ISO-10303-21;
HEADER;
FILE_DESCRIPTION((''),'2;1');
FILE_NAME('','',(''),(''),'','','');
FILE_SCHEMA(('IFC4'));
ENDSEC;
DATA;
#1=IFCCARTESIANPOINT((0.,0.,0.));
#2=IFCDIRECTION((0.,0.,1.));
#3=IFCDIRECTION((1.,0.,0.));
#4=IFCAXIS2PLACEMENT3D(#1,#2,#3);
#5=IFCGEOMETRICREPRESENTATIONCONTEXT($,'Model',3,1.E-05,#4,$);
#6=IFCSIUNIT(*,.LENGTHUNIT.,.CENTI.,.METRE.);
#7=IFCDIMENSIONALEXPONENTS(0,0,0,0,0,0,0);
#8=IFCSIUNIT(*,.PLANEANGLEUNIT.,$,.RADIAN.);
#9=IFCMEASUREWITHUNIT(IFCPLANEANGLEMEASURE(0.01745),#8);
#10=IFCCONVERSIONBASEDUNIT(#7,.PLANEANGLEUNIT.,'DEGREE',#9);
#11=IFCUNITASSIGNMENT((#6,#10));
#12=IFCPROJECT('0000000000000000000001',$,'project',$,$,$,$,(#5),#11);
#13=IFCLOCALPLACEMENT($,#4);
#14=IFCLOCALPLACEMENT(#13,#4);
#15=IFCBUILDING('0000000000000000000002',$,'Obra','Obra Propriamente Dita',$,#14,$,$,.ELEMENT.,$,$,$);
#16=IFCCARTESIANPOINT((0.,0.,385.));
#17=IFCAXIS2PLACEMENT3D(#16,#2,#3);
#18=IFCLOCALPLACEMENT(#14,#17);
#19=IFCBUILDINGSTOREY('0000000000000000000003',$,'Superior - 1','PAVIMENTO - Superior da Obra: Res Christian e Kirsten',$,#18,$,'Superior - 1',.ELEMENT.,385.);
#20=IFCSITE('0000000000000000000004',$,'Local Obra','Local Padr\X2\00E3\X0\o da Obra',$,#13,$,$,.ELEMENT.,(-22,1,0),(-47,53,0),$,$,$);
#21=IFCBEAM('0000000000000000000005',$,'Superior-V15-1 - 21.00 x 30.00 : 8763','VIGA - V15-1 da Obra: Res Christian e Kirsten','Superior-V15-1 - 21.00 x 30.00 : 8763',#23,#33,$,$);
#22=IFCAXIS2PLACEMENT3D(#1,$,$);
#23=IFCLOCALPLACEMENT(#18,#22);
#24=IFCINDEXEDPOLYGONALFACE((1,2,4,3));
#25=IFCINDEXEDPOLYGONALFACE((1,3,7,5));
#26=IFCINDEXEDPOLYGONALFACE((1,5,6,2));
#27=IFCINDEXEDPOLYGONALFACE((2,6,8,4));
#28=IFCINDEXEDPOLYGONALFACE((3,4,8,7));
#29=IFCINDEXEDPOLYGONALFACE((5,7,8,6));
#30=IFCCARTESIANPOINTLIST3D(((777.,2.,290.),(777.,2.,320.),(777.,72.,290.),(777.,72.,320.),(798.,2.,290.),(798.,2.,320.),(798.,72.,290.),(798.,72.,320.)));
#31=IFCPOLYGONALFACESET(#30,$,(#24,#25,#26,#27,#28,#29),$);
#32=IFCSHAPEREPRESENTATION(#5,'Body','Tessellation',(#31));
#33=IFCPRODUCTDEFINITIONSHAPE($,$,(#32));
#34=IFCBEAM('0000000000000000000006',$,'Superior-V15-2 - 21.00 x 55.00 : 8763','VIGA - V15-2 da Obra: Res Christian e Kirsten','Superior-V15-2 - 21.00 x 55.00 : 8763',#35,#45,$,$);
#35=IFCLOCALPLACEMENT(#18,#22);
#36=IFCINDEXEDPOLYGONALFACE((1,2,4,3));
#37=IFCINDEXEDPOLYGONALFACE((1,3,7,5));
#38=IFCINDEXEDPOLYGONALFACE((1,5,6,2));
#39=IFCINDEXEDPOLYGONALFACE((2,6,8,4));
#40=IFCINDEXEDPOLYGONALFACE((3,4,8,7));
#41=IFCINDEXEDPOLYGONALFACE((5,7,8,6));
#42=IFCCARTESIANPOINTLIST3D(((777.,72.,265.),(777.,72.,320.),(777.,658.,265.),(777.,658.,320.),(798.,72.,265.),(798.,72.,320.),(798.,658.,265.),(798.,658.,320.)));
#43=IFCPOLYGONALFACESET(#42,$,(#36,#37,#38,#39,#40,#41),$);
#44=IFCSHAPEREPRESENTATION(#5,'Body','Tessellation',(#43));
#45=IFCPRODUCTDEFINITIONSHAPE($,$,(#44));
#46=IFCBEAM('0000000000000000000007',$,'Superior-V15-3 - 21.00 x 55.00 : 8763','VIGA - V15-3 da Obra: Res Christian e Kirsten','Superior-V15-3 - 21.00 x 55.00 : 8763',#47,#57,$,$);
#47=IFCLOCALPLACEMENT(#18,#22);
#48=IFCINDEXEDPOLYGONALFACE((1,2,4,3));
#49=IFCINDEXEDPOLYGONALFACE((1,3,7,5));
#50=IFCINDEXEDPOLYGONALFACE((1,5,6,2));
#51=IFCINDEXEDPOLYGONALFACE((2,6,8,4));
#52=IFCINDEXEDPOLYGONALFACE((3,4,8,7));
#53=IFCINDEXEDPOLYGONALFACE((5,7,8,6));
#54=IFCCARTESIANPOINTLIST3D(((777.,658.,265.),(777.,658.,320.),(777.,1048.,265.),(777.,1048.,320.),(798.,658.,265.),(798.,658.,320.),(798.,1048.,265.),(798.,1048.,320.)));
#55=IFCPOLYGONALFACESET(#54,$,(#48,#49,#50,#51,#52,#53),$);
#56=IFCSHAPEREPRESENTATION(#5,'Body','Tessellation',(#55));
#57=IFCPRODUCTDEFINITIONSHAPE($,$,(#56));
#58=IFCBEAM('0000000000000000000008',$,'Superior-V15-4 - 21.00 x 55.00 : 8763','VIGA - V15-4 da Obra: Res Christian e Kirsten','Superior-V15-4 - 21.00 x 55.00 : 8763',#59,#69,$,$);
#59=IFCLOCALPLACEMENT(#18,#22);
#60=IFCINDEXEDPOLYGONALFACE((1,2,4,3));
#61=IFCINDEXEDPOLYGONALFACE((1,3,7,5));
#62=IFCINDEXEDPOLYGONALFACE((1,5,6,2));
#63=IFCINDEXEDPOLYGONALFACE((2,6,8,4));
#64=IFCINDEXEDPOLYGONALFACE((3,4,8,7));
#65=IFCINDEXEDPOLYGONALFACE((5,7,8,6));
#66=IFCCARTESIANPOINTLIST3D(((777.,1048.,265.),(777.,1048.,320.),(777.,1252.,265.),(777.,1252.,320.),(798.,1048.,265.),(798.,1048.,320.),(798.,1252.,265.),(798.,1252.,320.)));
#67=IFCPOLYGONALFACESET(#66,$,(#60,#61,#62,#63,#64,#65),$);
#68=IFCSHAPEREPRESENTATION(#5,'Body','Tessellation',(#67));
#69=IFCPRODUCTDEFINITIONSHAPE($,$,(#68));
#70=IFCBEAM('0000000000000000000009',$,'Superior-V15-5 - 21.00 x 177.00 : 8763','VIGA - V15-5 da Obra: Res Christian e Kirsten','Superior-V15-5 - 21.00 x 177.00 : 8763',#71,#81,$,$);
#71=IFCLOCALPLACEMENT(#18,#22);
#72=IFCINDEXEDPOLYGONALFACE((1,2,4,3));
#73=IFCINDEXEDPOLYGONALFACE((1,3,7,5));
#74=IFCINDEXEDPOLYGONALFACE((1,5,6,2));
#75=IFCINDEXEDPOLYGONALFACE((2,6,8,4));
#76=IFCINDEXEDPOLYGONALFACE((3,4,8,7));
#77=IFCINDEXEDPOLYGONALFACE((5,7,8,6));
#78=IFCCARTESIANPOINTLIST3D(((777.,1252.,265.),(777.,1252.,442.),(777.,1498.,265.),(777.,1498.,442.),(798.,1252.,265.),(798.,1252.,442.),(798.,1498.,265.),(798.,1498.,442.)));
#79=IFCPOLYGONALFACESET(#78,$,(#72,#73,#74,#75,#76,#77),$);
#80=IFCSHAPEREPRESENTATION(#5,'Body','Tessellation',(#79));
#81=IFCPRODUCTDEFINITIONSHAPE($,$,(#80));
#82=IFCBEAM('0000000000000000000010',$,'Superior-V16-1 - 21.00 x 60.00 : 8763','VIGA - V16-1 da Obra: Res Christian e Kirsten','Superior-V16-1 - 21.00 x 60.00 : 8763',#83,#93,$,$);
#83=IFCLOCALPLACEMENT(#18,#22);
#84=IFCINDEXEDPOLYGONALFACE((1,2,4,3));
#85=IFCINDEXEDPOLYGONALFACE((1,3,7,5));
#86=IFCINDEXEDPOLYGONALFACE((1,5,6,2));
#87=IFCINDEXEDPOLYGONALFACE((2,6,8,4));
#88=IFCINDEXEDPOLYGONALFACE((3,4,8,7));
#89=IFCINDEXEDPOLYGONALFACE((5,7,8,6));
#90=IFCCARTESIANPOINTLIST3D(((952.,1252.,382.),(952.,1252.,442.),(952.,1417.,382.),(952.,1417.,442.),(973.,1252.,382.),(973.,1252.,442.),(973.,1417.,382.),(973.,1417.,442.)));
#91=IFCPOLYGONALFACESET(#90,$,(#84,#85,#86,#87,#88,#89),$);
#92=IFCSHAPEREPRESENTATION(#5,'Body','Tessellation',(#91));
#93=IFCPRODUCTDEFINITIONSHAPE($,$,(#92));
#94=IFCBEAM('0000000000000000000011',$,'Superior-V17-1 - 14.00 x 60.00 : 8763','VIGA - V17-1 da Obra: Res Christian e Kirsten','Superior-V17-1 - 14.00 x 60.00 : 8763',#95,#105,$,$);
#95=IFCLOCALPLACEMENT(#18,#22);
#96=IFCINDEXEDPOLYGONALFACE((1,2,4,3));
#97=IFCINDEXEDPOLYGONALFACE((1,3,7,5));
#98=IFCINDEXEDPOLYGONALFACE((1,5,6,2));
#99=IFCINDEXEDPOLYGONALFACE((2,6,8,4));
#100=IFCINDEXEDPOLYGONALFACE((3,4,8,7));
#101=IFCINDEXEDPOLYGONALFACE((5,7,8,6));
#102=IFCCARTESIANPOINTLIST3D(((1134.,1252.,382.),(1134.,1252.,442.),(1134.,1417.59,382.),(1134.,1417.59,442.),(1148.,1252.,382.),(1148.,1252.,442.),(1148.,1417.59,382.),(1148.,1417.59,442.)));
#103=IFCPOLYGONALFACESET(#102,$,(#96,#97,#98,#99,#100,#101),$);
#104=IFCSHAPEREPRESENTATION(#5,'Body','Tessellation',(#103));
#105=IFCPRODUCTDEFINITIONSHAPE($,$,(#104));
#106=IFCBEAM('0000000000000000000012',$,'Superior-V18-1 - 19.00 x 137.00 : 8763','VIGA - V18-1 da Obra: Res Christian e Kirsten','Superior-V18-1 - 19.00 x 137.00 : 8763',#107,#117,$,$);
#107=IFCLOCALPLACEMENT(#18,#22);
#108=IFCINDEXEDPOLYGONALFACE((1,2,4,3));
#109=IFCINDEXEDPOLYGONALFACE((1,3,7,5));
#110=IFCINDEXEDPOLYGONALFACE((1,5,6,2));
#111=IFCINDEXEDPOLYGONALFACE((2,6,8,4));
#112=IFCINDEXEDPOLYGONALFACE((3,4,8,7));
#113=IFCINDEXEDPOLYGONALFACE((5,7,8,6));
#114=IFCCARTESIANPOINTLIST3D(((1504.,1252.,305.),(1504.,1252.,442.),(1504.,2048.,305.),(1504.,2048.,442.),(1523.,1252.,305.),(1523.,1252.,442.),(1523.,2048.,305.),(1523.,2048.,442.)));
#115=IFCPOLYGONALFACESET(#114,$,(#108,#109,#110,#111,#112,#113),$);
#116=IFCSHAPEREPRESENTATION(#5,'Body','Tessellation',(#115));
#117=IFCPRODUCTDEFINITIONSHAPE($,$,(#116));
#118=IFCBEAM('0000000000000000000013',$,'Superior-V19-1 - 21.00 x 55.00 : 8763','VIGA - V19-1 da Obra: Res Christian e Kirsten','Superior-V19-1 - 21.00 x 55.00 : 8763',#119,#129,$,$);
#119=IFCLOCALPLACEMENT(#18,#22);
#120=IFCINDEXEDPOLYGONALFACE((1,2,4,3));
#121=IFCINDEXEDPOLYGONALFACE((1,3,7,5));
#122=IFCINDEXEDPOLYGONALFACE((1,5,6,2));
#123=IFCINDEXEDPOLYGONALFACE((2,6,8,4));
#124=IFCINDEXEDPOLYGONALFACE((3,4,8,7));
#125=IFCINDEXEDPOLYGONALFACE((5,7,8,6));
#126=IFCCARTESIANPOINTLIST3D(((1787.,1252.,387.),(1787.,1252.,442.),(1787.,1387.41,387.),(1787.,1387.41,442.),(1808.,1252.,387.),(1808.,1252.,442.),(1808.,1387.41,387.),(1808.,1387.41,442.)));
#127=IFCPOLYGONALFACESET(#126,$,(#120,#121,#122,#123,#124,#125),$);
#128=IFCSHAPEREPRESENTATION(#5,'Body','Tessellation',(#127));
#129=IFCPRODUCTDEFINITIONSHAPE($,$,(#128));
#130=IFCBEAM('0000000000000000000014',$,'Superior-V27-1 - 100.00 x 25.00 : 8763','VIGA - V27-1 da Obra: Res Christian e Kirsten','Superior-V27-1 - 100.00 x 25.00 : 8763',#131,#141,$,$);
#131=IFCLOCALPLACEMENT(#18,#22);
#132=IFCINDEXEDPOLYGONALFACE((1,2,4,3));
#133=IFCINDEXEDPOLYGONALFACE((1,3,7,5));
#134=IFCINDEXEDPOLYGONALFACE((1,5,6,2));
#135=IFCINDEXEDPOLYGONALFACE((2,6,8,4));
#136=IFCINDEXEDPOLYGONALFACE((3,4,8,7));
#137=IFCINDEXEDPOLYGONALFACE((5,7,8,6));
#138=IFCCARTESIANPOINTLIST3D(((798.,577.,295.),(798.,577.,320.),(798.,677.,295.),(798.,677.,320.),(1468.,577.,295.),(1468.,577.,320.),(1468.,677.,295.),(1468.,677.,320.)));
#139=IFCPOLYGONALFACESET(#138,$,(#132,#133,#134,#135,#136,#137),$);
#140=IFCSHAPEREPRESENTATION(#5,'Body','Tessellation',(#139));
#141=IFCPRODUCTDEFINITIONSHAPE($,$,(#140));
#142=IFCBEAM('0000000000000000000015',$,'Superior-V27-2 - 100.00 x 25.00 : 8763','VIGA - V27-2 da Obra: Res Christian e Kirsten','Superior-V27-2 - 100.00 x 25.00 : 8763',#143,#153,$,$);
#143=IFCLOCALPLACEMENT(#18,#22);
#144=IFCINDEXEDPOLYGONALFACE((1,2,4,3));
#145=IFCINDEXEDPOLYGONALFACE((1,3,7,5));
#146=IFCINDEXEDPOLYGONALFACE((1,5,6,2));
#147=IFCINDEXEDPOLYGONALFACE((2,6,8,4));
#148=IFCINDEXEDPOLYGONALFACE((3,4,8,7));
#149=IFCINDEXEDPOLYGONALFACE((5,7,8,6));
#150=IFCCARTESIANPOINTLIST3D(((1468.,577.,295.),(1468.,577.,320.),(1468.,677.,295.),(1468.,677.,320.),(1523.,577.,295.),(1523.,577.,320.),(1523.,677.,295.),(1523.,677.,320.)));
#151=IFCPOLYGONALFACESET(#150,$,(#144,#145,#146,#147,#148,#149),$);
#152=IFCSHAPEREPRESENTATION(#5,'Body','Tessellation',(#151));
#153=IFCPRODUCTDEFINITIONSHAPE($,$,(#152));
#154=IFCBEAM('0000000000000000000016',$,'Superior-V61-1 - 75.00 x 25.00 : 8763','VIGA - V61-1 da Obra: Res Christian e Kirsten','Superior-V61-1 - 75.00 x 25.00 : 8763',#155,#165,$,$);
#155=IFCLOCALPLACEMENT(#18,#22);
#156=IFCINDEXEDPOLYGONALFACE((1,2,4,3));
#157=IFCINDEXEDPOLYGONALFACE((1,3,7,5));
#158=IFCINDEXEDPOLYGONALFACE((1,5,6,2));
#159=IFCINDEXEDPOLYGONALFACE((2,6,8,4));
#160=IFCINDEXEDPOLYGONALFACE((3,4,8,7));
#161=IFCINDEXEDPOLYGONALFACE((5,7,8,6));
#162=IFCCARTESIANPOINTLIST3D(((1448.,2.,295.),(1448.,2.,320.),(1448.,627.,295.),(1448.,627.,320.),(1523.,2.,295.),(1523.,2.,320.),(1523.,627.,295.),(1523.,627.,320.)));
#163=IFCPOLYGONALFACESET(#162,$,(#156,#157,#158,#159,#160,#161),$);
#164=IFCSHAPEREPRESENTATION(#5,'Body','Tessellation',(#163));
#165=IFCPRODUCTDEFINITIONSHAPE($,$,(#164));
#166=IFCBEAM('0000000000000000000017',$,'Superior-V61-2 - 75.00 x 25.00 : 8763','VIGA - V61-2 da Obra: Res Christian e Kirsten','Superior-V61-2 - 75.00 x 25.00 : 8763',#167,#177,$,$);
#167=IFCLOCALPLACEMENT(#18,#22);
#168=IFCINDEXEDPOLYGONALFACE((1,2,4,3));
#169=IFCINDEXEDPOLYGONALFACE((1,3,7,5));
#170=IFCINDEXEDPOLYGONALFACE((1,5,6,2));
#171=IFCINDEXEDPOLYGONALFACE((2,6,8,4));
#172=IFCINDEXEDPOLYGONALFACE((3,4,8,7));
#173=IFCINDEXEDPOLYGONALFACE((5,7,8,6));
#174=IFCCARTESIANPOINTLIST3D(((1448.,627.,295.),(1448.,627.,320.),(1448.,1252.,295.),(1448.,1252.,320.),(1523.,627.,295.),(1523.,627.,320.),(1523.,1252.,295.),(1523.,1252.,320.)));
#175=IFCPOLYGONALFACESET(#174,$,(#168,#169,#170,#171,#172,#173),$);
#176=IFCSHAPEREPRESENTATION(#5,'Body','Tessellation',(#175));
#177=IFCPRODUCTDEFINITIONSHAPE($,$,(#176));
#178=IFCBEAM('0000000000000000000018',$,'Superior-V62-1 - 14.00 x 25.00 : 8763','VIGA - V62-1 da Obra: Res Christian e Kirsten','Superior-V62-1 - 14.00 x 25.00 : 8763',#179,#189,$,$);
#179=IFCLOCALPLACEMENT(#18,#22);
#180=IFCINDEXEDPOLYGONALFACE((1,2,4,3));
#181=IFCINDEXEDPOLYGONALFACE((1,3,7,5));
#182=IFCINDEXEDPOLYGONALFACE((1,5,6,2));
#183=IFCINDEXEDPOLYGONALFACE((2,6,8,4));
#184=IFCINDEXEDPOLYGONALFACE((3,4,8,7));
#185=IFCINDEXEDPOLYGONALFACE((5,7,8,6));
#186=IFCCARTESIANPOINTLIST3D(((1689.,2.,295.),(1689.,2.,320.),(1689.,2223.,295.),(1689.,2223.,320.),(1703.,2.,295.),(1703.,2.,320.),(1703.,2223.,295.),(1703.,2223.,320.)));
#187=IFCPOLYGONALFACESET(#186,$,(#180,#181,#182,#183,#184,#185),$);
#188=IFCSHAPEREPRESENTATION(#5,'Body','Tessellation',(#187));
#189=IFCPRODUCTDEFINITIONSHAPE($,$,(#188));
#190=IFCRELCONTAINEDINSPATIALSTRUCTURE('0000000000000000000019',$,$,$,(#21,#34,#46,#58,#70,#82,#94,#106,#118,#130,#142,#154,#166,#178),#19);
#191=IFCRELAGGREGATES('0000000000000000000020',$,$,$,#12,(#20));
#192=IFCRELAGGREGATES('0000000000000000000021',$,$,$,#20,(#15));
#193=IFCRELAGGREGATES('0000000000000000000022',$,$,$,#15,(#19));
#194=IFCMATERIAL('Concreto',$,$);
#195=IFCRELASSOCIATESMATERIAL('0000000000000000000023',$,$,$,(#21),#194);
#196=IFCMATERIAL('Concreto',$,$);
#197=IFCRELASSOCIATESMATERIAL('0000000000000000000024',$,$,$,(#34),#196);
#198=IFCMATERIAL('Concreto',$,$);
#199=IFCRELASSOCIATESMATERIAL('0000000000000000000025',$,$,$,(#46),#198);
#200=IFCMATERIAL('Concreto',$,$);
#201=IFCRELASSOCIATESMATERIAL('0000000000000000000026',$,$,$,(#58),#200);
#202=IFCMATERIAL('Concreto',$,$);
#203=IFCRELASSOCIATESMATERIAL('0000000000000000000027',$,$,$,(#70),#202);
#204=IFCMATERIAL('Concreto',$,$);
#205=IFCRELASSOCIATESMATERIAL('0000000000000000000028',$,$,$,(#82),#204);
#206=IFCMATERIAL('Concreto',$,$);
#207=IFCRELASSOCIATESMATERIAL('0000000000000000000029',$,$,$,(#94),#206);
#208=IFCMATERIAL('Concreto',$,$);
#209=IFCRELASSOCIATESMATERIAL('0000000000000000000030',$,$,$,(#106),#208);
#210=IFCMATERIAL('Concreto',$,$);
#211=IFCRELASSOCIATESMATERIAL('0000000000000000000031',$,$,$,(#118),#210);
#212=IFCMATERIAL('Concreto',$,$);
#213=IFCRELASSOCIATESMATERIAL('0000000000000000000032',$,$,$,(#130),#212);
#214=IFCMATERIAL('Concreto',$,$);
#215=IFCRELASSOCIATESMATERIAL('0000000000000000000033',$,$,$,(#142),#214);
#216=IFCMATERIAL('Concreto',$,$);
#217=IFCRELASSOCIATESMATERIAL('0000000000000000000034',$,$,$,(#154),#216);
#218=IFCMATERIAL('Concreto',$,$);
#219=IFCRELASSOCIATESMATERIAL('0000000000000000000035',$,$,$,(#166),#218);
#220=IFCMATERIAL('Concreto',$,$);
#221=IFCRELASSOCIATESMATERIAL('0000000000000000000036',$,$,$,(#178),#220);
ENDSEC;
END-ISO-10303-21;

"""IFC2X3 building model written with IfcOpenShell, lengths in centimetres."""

from ifc_helpers import new_model, entity, si_unit, converted_unit, frame, origin_with_axes, place, context, project, spatial, polyline, outline, extrude, material, element, save


model = new_model("IFC2X3")

# Units and contexts
model_context = context("Model", 3, precision=1e-05, world=origin_with_axes())
ifc_project = project(units=[si_unit("LENGTHUNIT", "METRE", prefix="CENTI"), converted_unit("PLANEANGLEUNIT", "DEGREE", entity("IfcPlaneAngleMeasure", 0.01745), si_unit("PLANEANGLEUNIT", "RADIAN"), dimensions=[0, 0, 0, 0, 0, 0, 0])], contexts=[model_context])

# Site, building, storey
site_placement = place(None, origin_with_axes())
site = spatial("IfcSite", under=ifc_project, at=site_placement, Name="Local Obra", Description="Local Padrão da Obra", CompositionType="ELEMENT", RefLatitude=(-22, 1, 0), RefLongitude=(-47, 53, 0))
building_placement = place(site_placement, origin_with_axes())
building = spatial("IfcBuilding", under=site, at=building_placement, Name="Obra", Description="Obra Propriamente Dita", CompositionType="ELEMENT")
storey_placement = place(building_placement, frame((0.0, 0.0, 385.0), z_axis=(0.0, 0.0, 1.0), x_axis=(1.0, 0.0, 0.0)))
storey = spatial("IfcBuildingStorey", under=building, at=storey_placement, Name="Superior - 1", Description="PAVIMENTO - Superior da Obra: Res Christian e Kirsten", LongName="Superior - 1", CompositionType="ELEMENT", Elevation=385.0)

# Beams
ifc_material_1 = material(Name="Concreto")
beam_1_placement = place(storey_placement, frame((787.5, 2.0, 320.0), z_axis=(0.0, 1.0, 0.0), x_axis=(1.0, 0.0, 0.0)))
element("IfcBeam", 1, at=beam_1_placement, inside=storey, material=ifc_material_1, Name="Superior-V15-1 - 21.00 x 30.00 : 8763", Description="VIGA - V15-1 da Obra: Res Christian e Kirsten", ObjectType="Superior-V15-1 - 21.00 x 30.00 : 8763", context=model_context, shape_type="SweptSolid", body=[
    extrude(outline(polyline([(-10.5, 0.0), (10.5, 0.0), (10.5, 30.0), (-10.5, 30.0), (-10.5, 0.0)])), origin_with_axes(), (0.0, 0.0, 1.0), 70.0),
])
ifc_material_2 = material(Name="Concreto")
beam_2_placement = place(storey_placement, frame((787.5, 72.0, 320.0), z_axis=(0.0, 1.0, 0.0), x_axis=(1.0, 0.0, 0.0)))
element("IfcBeam", 2, at=beam_2_placement, inside=storey, material=ifc_material_2, Name="Superior-V15-2 - 21.00 x 55.00 : 8763", Description="VIGA - V15-2 da Obra: Res Christian e Kirsten", ObjectType="Superior-V15-2 - 21.00 x 55.00 : 8763", context=model_context, shape_type="SweptSolid", body=[
    extrude(outline(polyline([(-10.5, 0.0), (10.5, 0.0), (10.5, 55.0), (-10.5, 55.0), (-10.5, 0.0)])), origin_with_axes(), (0.0, 0.0, 1.0), 586.0),
])
ifc_material_3 = material(Name="Concreto")
beam_3_placement = place(storey_placement, frame((787.5, 658.0, 320.0), z_axis=(0.0, 1.0, 0.0), x_axis=(1.0, 0.0, 0.0)))
element("IfcBeam", 3, at=beam_3_placement, inside=storey, material=ifc_material_3, Name="Superior-V15-3 - 21.00 x 55.00 : 8763", Description="VIGA - V15-3 da Obra: Res Christian e Kirsten", ObjectType="Superior-V15-3 - 21.00 x 55.00 : 8763", context=model_context, shape_type="SweptSolid", body=[
    extrude(outline(polyline([(-10.5, 0.0), (10.5, 0.0), (10.5, 55.0), (-10.5, 55.0), (-10.5, 0.0)])), origin_with_axes(), (0.0, 0.0, 1.0), 390.0),
])
ifc_material_4 = material(Name="Concreto")
beam_4_placement = place(storey_placement, frame((787.5, 1048.0, 320.0), z_axis=(0.0, 1.0, 0.0), x_axis=(1.0, 0.0, 0.0)))
element("IfcBeam", 4, at=beam_4_placement, inside=storey, material=ifc_material_4, Name="Superior-V15-4 - 21.00 x 55.00 : 8763", Description="VIGA - V15-4 da Obra: Res Christian e Kirsten", ObjectType="Superior-V15-4 - 21.00 x 55.00 : 8763", context=model_context, shape_type="SweptSolid", body=[
    extrude(outline(polyline([(-10.5, 0.0), (10.5, 0.0), (10.5, 55.0), (-10.5, 55.0), (-10.5, 0.0)])), origin_with_axes(), (0.0, 0.0, 1.0), 204.0),
])
ifc_material_5 = material(Name="Concreto")
beam_5_placement = place(storey_placement, frame((787.5, 1252.0, 442.0), z_axis=(0.0, 1.0, 0.0), x_axis=(1.0, 0.0, 0.0)))
element("IfcBeam", 5, at=beam_5_placement, inside=storey, material=ifc_material_5, Name="Superior-V15-5 - 21.00 x 177.00 : 8763", Description="VIGA - V15-5 da Obra: Res Christian e Kirsten", ObjectType="Superior-V15-5 - 21.00 x 177.00 : 8763", context=model_context, shape_type="SweptSolid", body=[
    extrude(outline(polyline([(-10.5, 0.0), (10.5, 0.0), (10.5, 177.0), (-10.5, 177.0), (-10.5, 0.0)])), origin_with_axes(), (0.0, 0.0, 1.0), 246.0),
])
ifc_material_6 = material(Name="Concreto")
beam_6_placement = place(storey_placement, frame((952.0, 1252.0, 442.0), z_axis=(0.0, 1.0, 0.0), x_axis=(1.0, 0.0, 0.0)))
element("IfcBeam", 6, at=beam_6_placement, inside=storey, material=ifc_material_6, Name="Superior-V16-1 - 21.00 x 60.00 : 8763", Description="VIGA - V16-1 da Obra: Res Christian e Kirsten", ObjectType="Superior-V16-1 - 21.00 x 60.00 : 8763", context=model_context, shape_type="SweptSolid", body=[
    extrude(outline(polyline([(0.0, 0.0), (21.0, 0.0), (21.0, 60.0), (0.0, 60.0), (0.0, 0.0)])), origin_with_axes(), (0.0, 0.0, 1.0), 165.0),
])
ifc_material_7 = material(Name="Concreto")
beam_7_placement = place(storey_placement, frame((1134.0, 1252.0, 442.0), z_axis=(0.0, 1.0, 0.0), x_axis=(1.0, 0.0, 0.0)))
element("IfcBeam", 7, at=beam_7_placement, inside=storey, material=ifc_material_7, Name="Superior-V17-1 - 14.00 x 60.00 : 8763", Description="VIGA - V17-1 da Obra: Res Christian e Kirsten", ObjectType="Superior-V17-1 - 14.00 x 60.00 : 8763", context=model_context, shape_type="SweptSolid", body=[
    extrude(outline(polyline([(0.0, 0.0), (14.0, 0.0), (14.0, 60.0), (0.0, 60.0), (0.0, 0.0)])), origin_with_axes(), (0.0, 0.0, 1.0), 165.59),
])
ifc_material_8 = material(Name="Concreto")
beam_8_placement = place(storey_placement, frame((1523.0, 1252.0, 442.0), z_axis=(0.0, 1.0, 0.0), x_axis=(1.0, 0.0, 0.0)))
element("IfcBeam", 8, at=beam_8_placement, inside=storey, material=ifc_material_8, Name="Superior-V18-1 - 19.00 x 137.00 : 8763", Description="VIGA - V18-1 da Obra: Res Christian e Kirsten", ObjectType="Superior-V18-1 - 19.00 x 137.00 : 8763", context=model_context, shape_type="SweptSolid", body=[
    extrude(outline(polyline([(-19.0, 0.0), (0.0, 0.0), (0.0, 137.0), (-19.0, 137.0), (-19.0, 0.0)])), origin_with_axes(), (0.0, 0.0, 1.0), 796.0),
])
ifc_material_9 = material(Name="Concreto")
beam_9_placement = place(storey_placement, frame((1797.5, 1252.0, 442.0), z_axis=(0.0, 1.0, 0.0), x_axis=(1.0, 0.0, 0.0)))
element("IfcBeam", 9, at=beam_9_placement, inside=storey, material=ifc_material_9, Name="Superior-V19-1 - 21.00 x 55.00 : 8763", Description="VIGA - V19-1 da Obra: Res Christian e Kirsten", ObjectType="Superior-V19-1 - 21.00 x 55.00 : 8763", context=model_context, shape_type="SweptSolid", body=[
    extrude(outline(polyline([(-10.5, 0.0), (10.5, 0.0), (10.5, 55.0), (-10.5, 55.0), (-10.5, 0.0)])), origin_with_axes(), (0.0, 0.0, 1.0), 135.41),
])
ifc_material_10 = material(Name="Concreto")
beam_10_placement = place(storey_placement, frame((798.0, 627.0, 320.0), z_axis=(1.0, 0.0, 0.0), x_axis=(0.0, -1.0, 0.0)))
element("IfcBeam", 10, at=beam_10_placement, inside=storey, material=ifc_material_10, Name="Superior-V27-1 - 100.00 x 25.00 : 8763", Description="VIGA - V27-1 da Obra: Res Christian e Kirsten", ObjectType="Superior-V27-1 - 100.00 x 25.00 : 8763", context=model_context, shape_type="SweptSolid", body=[
    extrude(outline(polyline([(-50.0, 0.0), (50.0, 0.0), (50.0, 25.0), (-50.0, 25.0), (-50.0, 0.0)])), origin_with_axes(), (0.0, 0.0, 1.0), 670.0),
])
ifc_material_11 = material(Name="Concreto")
beam_11_placement = place(storey_placement, frame((1468.0, 627.0, 320.0), z_axis=(1.0, 0.000002, 0.0), x_axis=(0.000002, -1.0, 0.0)))
element("IfcBeam", 11, at=beam_11_placement, inside=storey, material=ifc_material_11, Name="Superior-V27-2 - 100.00 x 25.00 : 8763", Description="VIGA - V27-2 da Obra: Res Christian e Kirsten", ObjectType="Superior-V27-2 - 100.00 x 25.00 : 8763", context=model_context, shape_type="SweptSolid", body=[
    extrude(outline(polyline([(-50.0, 0.0), (50.0, 0.0), (50.0, 25.0), (-50.0, 25.0), (-50.0, 0.0)])), origin_with_axes(), (0.0, 0.0, 1.0), 55.0),
])
ifc_material_12 = material(Name="Concreto")
beam_12_placement = place(storey_placement, frame((1523.0, 2.0, 320.0), z_axis=(0.0, 1.0, 0.0), x_axis=(1.0, 0.0, 0.0)))
element("IfcBeam", 12, at=beam_12_placement, inside=storey, material=ifc_material_12, Name="Superior-V61-1 - 75.00 x 25.00 : 8763", Description="VIGA - V61-1 da Obra: Res Christian e Kirsten", ObjectType="Superior-V61-1 - 75.00 x 25.00 : 8763", context=model_context, shape_type="SweptSolid", body=[
    extrude(outline(polyline([(-75.0, 0.0), (0.0, 0.0), (0.0, 25.0), (-75.0, 25.0), (-75.0, 0.0)])), origin_with_axes(), (0.0, 0.0, 1.0), 625.0),
])
ifc_material_13 = material(Name="Concreto")
beam_13_placement = place(storey_placement, frame((1523.0, 627.0, 320.0), z_axis=(0.0, 1.0, 0.0), x_axis=(1.0, 0.0, 0.0)))
element("IfcBeam", 13, at=beam_13_placement, inside=storey, material=ifc_material_13, Name="Superior-V61-2 - 75.00 x 25.00 : 8763", Description="VIGA - V61-2 da Obra: Res Christian e Kirsten", ObjectType="Superior-V61-2 - 75.00 x 25.00 : 8763", context=model_context, shape_type="SweptSolid", body=[
    extrude(outline(polyline([(-75.0, 0.0), (0.0, 0.0), (0.0, 25.0), (-75.0, 25.0), (-75.0, 0.0)])), origin_with_axes(), (0.0, 0.0, 1.0), 625.0),
])
ifc_material_14 = material(Name="Concreto")
beam_14_placement = place(storey_placement, frame((1703.0, 2.0, 320.0), z_axis=(0.0, 1.0, 0.0), x_axis=(1.0, 0.0, 0.0)))
element("IfcBeam", 14, at=beam_14_placement, inside=storey, material=ifc_material_14, Name="Superior-V62-1 - 14.00 x 25.00 : 8763", Description="VIGA - V62-1 da Obra: Res Christian e Kirsten", ObjectType="Superior-V62-1 - 14.00 x 25.00 : 8763", context=model_context, shape_type="SweptSolid", body=[
    extrude(outline(polyline([(-14.0, 0.0), (0.0, 0.0), (0.0, 25.0), (-14.0, 25.0), (-14.0, 0.0)])), origin_with_axes(), (0.0, 0.0, 1.0), 2221.0),
])

save(model, "model.ifc")
